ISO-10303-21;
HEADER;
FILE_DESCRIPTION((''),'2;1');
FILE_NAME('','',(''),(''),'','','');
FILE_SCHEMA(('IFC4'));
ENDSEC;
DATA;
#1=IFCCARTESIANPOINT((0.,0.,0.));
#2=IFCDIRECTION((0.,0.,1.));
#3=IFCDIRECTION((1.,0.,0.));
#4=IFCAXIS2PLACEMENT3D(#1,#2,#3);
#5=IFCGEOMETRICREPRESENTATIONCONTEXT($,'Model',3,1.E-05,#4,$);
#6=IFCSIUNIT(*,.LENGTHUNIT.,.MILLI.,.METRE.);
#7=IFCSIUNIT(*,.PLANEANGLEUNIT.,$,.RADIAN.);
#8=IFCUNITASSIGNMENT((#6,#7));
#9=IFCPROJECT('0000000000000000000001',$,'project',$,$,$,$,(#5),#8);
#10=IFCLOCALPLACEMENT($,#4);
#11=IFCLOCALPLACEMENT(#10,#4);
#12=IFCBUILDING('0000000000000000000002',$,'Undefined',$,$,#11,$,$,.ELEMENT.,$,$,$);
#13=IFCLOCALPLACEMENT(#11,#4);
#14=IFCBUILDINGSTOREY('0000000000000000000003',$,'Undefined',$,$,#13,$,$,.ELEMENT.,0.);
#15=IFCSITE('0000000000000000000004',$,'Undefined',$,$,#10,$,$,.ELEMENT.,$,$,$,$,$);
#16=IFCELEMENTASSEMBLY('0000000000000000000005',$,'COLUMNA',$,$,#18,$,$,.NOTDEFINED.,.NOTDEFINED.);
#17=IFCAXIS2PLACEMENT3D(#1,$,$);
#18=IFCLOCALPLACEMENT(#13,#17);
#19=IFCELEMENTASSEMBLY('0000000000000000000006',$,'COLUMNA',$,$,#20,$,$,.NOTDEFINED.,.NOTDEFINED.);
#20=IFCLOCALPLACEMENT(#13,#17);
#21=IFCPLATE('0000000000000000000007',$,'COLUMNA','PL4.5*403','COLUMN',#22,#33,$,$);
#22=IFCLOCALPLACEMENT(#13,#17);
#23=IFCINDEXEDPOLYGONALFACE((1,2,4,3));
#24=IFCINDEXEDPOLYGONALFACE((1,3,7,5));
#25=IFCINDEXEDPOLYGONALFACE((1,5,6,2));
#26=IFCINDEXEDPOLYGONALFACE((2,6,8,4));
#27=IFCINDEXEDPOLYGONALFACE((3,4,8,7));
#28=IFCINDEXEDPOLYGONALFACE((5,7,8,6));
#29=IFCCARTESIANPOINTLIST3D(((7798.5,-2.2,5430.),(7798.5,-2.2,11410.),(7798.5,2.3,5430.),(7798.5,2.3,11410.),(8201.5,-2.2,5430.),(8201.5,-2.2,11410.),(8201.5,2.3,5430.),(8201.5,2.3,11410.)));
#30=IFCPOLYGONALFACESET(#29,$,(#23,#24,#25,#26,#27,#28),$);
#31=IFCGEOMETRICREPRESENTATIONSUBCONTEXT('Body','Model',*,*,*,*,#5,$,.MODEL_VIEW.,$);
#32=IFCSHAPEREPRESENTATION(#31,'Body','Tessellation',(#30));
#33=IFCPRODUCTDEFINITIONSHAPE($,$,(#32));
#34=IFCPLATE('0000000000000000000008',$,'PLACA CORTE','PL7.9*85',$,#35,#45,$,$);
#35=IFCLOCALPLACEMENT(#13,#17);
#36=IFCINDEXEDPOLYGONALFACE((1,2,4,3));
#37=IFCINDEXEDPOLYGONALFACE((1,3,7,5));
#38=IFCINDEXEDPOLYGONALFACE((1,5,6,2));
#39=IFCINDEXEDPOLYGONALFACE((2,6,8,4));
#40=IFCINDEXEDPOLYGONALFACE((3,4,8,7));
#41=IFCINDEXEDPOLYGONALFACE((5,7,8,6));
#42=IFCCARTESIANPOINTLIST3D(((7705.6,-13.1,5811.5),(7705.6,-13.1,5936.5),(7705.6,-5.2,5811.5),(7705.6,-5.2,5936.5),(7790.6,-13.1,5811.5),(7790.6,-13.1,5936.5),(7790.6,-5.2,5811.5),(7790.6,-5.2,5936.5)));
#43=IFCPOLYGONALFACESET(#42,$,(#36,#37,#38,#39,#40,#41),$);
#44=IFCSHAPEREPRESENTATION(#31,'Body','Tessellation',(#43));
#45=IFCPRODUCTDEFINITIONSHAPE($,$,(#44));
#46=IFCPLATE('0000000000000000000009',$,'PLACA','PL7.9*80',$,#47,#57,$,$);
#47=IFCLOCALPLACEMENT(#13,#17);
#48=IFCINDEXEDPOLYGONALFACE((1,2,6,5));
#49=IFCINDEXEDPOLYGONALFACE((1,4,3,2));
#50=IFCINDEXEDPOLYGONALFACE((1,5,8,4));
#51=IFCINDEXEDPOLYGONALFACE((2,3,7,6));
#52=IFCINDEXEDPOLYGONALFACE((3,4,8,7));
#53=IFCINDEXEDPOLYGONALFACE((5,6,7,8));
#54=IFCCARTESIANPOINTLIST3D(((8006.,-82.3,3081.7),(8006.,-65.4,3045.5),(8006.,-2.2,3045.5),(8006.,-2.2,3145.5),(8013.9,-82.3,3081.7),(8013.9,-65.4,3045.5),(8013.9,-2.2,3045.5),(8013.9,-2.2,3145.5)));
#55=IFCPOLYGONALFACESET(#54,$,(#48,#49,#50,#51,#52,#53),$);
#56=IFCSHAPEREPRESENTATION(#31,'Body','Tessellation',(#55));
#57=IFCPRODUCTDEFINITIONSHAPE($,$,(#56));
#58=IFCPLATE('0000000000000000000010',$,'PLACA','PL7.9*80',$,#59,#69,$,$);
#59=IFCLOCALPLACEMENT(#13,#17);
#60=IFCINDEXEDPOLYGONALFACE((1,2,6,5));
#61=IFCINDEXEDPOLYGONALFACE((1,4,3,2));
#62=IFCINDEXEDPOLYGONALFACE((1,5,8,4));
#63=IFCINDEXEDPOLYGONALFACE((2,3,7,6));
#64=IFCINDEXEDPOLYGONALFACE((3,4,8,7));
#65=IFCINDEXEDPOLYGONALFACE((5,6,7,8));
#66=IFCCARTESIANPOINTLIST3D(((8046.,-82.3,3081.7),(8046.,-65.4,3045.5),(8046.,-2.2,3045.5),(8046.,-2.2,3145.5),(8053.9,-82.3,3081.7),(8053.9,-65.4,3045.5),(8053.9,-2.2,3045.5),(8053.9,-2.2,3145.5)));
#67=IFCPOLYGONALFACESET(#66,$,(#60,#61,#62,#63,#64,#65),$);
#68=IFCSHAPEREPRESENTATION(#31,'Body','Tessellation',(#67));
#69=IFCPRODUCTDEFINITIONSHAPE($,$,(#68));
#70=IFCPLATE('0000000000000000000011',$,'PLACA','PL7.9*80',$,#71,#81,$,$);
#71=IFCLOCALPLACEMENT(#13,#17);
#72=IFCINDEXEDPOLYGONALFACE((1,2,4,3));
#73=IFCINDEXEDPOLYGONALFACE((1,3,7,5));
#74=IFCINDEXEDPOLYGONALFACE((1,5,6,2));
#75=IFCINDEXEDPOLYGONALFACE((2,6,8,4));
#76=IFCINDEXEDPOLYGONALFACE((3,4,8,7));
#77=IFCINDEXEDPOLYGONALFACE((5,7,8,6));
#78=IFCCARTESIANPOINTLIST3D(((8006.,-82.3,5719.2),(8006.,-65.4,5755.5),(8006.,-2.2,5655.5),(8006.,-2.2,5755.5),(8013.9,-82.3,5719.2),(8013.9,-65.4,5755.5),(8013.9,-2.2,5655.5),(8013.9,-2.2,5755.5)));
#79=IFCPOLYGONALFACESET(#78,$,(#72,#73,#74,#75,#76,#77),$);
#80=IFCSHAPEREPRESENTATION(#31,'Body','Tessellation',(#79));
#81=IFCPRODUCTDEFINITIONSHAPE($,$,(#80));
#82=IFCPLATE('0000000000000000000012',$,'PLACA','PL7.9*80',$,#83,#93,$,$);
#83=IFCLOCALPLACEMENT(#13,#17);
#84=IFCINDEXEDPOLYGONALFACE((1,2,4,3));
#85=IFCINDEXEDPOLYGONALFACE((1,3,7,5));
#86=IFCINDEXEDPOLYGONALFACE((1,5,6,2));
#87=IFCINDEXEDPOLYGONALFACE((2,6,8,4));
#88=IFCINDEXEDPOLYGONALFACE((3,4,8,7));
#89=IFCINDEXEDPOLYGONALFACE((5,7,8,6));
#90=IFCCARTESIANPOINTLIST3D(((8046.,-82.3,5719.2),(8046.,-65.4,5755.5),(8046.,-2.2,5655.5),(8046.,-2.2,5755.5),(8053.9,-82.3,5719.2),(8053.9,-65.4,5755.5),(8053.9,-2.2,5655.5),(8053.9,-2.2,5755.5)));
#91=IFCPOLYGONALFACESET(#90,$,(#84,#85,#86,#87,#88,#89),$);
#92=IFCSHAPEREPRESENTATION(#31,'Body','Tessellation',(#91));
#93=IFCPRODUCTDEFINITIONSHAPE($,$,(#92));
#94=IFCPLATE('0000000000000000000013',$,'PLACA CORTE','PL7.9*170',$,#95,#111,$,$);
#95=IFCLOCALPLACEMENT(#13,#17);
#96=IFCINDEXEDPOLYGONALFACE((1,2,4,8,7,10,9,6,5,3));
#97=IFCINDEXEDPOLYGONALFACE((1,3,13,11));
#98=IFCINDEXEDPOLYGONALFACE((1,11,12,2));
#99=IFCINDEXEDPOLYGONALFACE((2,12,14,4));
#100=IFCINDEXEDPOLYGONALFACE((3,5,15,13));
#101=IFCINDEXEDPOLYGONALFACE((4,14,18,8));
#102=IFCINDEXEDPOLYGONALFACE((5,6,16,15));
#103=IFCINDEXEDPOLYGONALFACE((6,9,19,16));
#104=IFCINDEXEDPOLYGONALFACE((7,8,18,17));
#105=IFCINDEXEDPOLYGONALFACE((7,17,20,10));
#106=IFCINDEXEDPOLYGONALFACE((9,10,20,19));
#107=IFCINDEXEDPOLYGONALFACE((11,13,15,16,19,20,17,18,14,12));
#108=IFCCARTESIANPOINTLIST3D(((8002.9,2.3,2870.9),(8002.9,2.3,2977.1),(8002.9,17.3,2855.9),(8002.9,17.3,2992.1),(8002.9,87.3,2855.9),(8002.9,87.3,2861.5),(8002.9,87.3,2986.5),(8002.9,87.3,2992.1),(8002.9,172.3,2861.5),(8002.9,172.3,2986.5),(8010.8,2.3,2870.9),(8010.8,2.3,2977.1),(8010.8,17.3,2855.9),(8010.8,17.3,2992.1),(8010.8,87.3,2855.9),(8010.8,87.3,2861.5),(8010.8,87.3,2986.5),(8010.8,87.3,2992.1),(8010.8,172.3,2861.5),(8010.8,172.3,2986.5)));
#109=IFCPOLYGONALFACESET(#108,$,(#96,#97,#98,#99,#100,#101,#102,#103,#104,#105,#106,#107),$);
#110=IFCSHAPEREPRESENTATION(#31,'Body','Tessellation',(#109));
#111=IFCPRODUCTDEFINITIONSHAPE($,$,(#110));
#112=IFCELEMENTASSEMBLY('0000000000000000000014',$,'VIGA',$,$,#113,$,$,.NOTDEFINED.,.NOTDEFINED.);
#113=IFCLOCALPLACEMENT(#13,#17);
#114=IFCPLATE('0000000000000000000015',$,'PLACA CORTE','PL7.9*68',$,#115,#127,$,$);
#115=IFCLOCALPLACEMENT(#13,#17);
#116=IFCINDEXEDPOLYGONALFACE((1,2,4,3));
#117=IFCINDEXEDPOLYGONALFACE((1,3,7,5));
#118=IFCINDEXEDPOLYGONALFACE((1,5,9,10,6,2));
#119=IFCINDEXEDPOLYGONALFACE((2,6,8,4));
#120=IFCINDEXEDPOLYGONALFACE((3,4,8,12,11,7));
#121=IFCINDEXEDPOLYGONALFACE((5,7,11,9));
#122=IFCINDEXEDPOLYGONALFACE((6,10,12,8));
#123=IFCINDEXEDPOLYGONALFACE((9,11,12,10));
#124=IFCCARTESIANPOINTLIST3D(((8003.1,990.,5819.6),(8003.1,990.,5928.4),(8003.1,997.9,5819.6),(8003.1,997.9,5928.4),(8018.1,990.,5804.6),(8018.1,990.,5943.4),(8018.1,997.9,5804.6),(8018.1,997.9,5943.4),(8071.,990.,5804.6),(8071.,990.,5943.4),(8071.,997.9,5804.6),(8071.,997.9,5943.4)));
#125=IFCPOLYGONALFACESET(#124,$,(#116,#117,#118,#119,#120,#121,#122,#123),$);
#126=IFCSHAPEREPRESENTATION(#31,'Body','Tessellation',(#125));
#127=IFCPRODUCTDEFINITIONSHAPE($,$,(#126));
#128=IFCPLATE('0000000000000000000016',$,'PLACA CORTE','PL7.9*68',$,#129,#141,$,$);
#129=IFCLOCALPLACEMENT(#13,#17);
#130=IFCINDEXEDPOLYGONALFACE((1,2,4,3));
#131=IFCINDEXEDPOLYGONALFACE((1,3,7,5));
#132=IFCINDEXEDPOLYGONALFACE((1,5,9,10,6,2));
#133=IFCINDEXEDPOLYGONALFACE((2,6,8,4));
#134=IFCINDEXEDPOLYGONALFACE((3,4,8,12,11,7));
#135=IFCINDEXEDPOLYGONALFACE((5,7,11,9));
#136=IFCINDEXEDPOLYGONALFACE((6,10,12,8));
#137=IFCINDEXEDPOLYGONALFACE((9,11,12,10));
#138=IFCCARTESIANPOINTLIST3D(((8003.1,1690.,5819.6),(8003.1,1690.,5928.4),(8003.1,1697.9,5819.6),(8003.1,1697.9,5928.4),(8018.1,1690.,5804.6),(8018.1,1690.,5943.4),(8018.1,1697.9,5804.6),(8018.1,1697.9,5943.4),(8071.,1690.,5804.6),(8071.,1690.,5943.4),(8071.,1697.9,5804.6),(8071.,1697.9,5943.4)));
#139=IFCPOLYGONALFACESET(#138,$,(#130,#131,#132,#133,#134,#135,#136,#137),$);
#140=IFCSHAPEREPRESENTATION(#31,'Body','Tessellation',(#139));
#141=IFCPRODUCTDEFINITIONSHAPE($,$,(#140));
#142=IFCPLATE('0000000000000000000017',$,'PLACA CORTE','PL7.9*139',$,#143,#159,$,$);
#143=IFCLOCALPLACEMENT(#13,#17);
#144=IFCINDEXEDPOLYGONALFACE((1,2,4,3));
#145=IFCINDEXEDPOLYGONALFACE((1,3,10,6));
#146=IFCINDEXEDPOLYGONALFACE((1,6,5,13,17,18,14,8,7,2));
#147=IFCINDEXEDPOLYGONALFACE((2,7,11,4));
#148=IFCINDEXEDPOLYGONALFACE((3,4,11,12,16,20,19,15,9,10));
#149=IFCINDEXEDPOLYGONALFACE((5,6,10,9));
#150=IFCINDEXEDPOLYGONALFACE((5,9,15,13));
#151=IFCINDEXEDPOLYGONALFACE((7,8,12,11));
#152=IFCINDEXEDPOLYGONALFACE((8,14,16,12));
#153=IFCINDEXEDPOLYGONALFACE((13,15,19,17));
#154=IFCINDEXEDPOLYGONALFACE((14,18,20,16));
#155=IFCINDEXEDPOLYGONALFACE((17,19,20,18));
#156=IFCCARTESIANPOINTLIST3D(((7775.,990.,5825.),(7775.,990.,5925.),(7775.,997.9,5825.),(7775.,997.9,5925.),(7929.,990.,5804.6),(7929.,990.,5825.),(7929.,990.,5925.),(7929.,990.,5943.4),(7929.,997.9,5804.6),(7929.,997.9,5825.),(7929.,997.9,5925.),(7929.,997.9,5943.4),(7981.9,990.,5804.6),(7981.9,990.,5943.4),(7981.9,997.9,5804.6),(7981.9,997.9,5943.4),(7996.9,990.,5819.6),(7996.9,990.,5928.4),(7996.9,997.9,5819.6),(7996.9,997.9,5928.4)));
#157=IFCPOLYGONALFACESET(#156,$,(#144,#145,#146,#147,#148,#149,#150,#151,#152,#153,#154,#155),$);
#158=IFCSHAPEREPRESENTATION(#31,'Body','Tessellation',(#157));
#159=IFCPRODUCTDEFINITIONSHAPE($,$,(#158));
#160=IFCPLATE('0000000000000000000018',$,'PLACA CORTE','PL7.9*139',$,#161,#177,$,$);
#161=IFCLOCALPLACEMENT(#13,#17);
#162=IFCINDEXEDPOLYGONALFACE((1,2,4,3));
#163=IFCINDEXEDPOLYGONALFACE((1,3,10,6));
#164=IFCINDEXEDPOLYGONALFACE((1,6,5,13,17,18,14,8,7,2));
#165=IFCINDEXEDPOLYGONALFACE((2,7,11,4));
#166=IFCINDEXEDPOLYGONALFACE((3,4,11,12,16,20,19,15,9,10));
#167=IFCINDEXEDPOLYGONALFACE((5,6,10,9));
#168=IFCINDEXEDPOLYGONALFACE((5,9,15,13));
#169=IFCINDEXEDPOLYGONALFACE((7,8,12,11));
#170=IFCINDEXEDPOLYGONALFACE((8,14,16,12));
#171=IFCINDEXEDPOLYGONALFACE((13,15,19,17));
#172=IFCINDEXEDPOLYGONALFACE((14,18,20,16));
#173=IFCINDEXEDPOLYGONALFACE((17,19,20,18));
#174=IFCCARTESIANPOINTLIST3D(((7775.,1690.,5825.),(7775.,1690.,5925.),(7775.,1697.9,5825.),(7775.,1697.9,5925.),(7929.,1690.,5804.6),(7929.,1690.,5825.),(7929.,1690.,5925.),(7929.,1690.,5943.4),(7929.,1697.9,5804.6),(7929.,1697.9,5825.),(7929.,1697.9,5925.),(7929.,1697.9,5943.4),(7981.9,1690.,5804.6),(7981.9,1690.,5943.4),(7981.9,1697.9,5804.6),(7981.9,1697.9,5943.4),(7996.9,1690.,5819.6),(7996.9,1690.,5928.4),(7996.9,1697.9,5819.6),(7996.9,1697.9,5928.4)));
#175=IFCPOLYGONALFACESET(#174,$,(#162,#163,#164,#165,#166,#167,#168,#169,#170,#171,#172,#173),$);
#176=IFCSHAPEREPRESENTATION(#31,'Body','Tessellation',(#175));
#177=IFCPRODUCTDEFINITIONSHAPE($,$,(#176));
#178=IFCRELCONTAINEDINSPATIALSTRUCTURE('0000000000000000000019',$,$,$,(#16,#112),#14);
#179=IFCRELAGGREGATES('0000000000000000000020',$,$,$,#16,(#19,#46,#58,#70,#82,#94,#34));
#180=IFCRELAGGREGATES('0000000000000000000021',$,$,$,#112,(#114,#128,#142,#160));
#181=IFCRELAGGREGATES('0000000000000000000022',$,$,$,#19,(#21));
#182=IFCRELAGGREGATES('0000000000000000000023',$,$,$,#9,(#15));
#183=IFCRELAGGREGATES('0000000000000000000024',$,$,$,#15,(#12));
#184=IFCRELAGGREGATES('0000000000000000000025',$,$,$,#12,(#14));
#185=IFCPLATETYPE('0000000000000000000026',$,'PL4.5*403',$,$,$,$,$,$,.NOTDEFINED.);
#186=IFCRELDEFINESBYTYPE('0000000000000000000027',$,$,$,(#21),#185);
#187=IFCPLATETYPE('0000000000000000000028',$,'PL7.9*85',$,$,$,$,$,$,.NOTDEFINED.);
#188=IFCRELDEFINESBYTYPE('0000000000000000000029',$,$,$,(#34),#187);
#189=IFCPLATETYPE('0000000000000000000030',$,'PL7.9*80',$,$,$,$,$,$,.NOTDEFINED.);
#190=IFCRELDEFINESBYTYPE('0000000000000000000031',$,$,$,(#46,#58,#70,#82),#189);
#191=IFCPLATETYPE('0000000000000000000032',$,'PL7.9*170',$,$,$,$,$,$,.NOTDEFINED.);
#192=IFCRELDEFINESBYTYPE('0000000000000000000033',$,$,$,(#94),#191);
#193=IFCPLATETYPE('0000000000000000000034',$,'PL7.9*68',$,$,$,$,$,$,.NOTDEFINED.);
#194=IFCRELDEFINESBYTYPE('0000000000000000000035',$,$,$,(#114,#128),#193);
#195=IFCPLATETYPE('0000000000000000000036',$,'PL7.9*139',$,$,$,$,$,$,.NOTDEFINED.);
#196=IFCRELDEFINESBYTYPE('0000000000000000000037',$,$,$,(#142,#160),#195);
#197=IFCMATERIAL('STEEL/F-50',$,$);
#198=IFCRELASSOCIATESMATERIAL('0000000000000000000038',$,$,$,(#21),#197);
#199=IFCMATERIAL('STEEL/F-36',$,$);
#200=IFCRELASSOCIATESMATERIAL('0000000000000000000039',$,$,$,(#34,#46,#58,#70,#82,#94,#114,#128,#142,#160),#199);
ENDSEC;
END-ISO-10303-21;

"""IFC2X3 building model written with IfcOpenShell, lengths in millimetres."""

from ifc_helpers import new_model, si_unit, frame, origin_with_axes, place, context, subcontext, project, spatial, polyline, outline, extrude, material, type_object, element, aggregate, save


model = new_model("IFC2X3")

# Units and contexts
model_context = context("Model", 3, precision=1e-05, world=origin_with_axes())
body_context = subcontext(model_context, "Body", "Model", "MODEL_VIEW")
ifc_project = project(units=[si_unit("LENGTHUNIT", "METRE", prefix="MILLI"), si_unit("PLANEANGLEUNIT", "RADIAN")], contexts=[model_context])

# Site, building, storey
site_placement = place(None, origin_with_axes())
site = spatial("IfcSite", under=ifc_project, at=site_placement, Name="Undefined", CompositionType="ELEMENT")
building_placement = place(site_placement, origin_with_axes())
building = spatial("IfcBuilding", under=site, at=building_placement, Name="Undefined", CompositionType="ELEMENT")
storey_placement = place(building_placement, origin_with_axes())
storey = spatial("IfcBuildingStorey", under=building, at=storey_placement, Name="Undefined", CompositionType="ELEMENT", Elevation=0.0)

# Element assembly
assembly_1_placement = place(storey_placement, origin_with_axes())
assembly_1 = element("IfcElementAssembly", 1, at=assembly_1_placement, inside=storey, Name="COLUMNA", AssemblyPlace="NOTDEFINED", PredefinedType="NOTDEFINED")
ifc_material_1 = material(Name="STEEL/F-50")

# Shared definitions
ifc_material_2 = material(Name="STEEL/F-36")

# Element assembly, plate
assembly_2_placement = place(assembly_1_placement, origin_with_axes())
assembly_2 = element("IfcElementAssembly", 2, at=assembly_2_placement, Name="COLUMNA", AssemblyPlace="NOTDEFINED", PredefinedType="NOTDEFINED")
plate_type_1 = type_object("IfcPlateType", Name="PL4.5*403", PredefinedType="NOTDEFINED")
plate_1_placement = place(assembly_2_placement, frame((8000.0, 0.0, 5430.0), z_axis=(0.0, -1.0, 0.0), x_axis=(0.0, 0.0, 1.0)))
plate_1 = element("IfcPlate", 3, at=plate_1_placement, type_object=plate_type_1, material=ifc_material_1, Name="COLUMNA", Description="PL4.5*403", ObjectType="COLUMN", context=body_context, shape_type="SweptSolid", body=[
    extrude(outline(polyline([(0.0, -201.5), (0.0, 201.5), (5980.0, 201.5), (5980.0, -201.5), (0.0, -201.5)])), frame((0.0, 0.0, -2.2), z_axis=(0.0, 0.0, 1.0), x_axis=(1.0, 0.0, 0.0)), (0.0, 0.0, 1.0), 4.5),
])

# Plates
plate_type_2 = type_object("IfcPlateType", Name="PL7.9*85", PredefinedType="NOTDEFINED")
plate_2_placement = place(assembly_1_placement, frame((7790.6, -9.1, 5811.5), z_axis=(0.000002, 1.0, 0.0), x_axis=(-1.0, 0.000002, 0.0)))
plate_2 = element("IfcPlate", 4, at=plate_2_placement, type_object=plate_type_2, material=ifc_material_2, Name="PLACA CORTE", Description="PL7.9*85", context=body_context, shape_type="SweptSolid", body=[
    extrude(outline(polyline([(0.0, 0.0), (85.0, 0.0), (85.0, 125.0), (0.0, 125.0), (0.0, 0.0)])), frame((0.0, 0.0, -4.0), z_axis=(0.0, 0.0, 1.0), x_axis=(1.0, 0.0, 0.0)), (0.0, 0.0, 1.0), 7.9),
])
plate_type_3 = type_object("IfcPlateType", Name="PL7.9*80", PredefinedType="NOTDEFINED")
plate_3_placement = place(assembly_1_placement, frame((8010.0, -2.2, 3045.5), z_axis=(-1.0, -0.000002, -0.000004), x_axis=(0.000002, -1.0, -0.000001)))
plate_3 = element("IfcPlate", 5, at=plate_3_placement, type_object=plate_type_3, material=ifc_material_2, Name="PLACA", Description="PL7.9*80", context=body_context, shape_type="SweptSolid", body=[
    extrude(outline(polyline([(0.0, 0.0), (63.2, 0.0), (80.1, 36.3), (0.0, 100.0), (0.0, 0.0)])), frame((0.0, 0.0, -4.0), z_axis=(0.0, 0.0, 1.0), x_axis=(1.0, 0.0, 0.0)), (0.0, 0.0, 1.0), 7.9),
])
plate_4_placement = place(assembly_1_placement, frame((8050.0, -2.2, 3045.5), z_axis=(-1.0, 0.000001, 0.0), x_axis=(-0.000001, -1.0, -0.000001)))
plate_4 = element("IfcPlate", 6, at=plate_4_placement, type_object=plate_type_3, material=ifc_material_2, Name="PLACA", Description="PL7.9*80", context=body_context, shape_type="SweptSolid", body=[
    extrude(outline(polyline([(0.0, 0.0), (63.2, 0.0), (80.1, 36.3), (0.0, 100.0), (0.0, 0.0)])), frame((0.0, 0.0, -4.0), z_axis=(0.0, 0.0, 1.0), x_axis=(1.0, 0.0, 0.0)), (0.0, 0.0, 1.0), 7.9),
])
plate_5_placement = place(assembly_1_placement, frame((8010.0, -2.2, 5755.5), z_axis=(1.0, 0.000001, -0.000004), x_axis=(0.000002, -1.0, 0.000001)))
plate_5 = element("IfcPlate", 7, at=plate_5_placement, type_object=plate_type_3, material=ifc_material_2, Name="PLACA", Description="PL7.9*80", context=body_context, shape_type="SweptSolid", body=[
    extrude(outline(polyline([(0.0, 0.0), (63.2, 0.0), (80.1, 36.3), (0.0, 100.0), (0.0, 0.0)])), frame((0.0, 0.0, -4.0), z_axis=(0.0, 0.0, 1.0), x_axis=(1.0, 0.0, 0.0)), (0.0, 0.0, 1.0), 7.9),
])
plate_6_placement = place(assembly_1_placement, frame((8050.0, -2.2, 5755.5), z_axis=(1.0, -0.000001, 0.0), x_axis=(-0.000001, -1.0, 0.000001)))
plate_6 = element("IfcPlate", 8, at=plate_6_placement, type_object=plate_type_3, material=ifc_material_2, Name="PLACA", Description="PL7.9*80", context=body_context, shape_type="SweptSolid", body=[
    extrude(outline(polyline([(0.0, 0.0), (63.2, 0.0), (80.1, 36.3), (0.0, 100.0), (0.0, 0.0)])), frame((0.0, 0.0, -4.0), z_axis=(0.0, 0.0, 1.0), x_axis=(1.0, 0.0, 0.0)), (0.0, 0.0, 1.0), 7.9),
])
plate_type_4 = type_object("IfcPlateType", Name="PL7.9*170", PredefinedType="NOTDEFINED")
plate_7_placement = place(assembly_1_placement, frame((8006.8, 2.3, 2992.1), z_axis=(1.0, 0.0, 0.0), x_axis=(0.0, 0.0, -1.0)))
plate_7 = element("IfcPlate", 9, at=plate_7_placement, type_object=plate_type_4, material=ifc_material_2, Name="PLACA CORTE", Description="PL7.9*170", context=body_context, shape_type="SweptSolid", body=[
    extrude(outline(polyline([(0.0, 15.0), (15.0, 0.0), (121.2, 0.0), (136.2, 15.0), (136.2, 85.0), (130.6, 85.0), (130.6, 170.0), (5.6, 170.0), (5.6, 85.0), (0.0, 85.0), (0.0, 15.0)])), frame((0.0, 0.0, -4.0), z_axis=(0.0, 0.0, 1.0), x_axis=(1.0, 0.0, 0.0)), (0.0, 0.0, 1.0), 7.9),
])
aggregate(assembly_1, [assembly_2, plate_3, plate_4, plate_5, plate_6, plate_7, plate_2])

# Element assembly, plates
assembly_3_placement = place(storey_placement, origin_with_axes())
assembly_3 = element("IfcElementAssembly", 10, at=assembly_3_placement, inside=storey, Name="VIGA", AssemblyPlace="NOTDEFINED", PredefinedType="NOTDEFINED")
plate_type_5 = type_object("IfcPlateType", Name="PL7.9*68", PredefinedType="NOTDEFINED")
plate_8_placement = place(assembly_3_placement, frame((8003.1, 993.9, 5804.6), z_axis=(0.000001, -1.0, 0.0), x_axis=(1.0, 0.000001, 0.0)))
plate_8 = element("IfcPlate", 11, at=plate_8_placement, type_object=plate_type_5, material=ifc_material_2, Name="PLACA CORTE", Description="PL7.9*68", context=body_context, shape_type="SweptSolid", body=[
    extrude(outline(polyline([(0.0, 15.0), (15.0, 0.0), (67.9, 0.0), (67.9, 138.8), (15.0, 138.8), (0.0, 123.8), (0.0, 15.0)])), frame((0.0, 0.0, -4.0), z_axis=(0.0, 0.0, 1.0), x_axis=(1.0, 0.0, 0.0)), (0.0, 0.0, 1.0), 7.9),
])
plate_9_placement = place(assembly_3_placement, frame((8003.1, 1693.9, 5804.6), z_axis=(0.000001, -1.0, 0.0), x_axis=(1.0, 0.000001, 0.0)))
plate_9 = element("IfcPlate", 12, at=plate_9_placement, type_object=plate_type_5, material=ifc_material_2, Name="PLACA CORTE", Description="PL7.9*68", context=body_context, shape_type="SweptSolid", body=[
    extrude(outline(polyline([(0.0, 15.0), (15.0, 0.0), (67.9, 0.0), (67.9, 138.8), (15.0, 138.8), (0.0, 123.8), (0.0, 15.0)])), frame((0.0, 0.0, -4.0), z_axis=(0.0, 0.0, 1.0), x_axis=(1.0, 0.0, 0.0)), (0.0, 0.0, 1.0), 7.9),
])
plate_type_6 = type_object("IfcPlateType", Name="PL7.9*139", PredefinedType="NOTDEFINED")
plate_10_placement = place(assembly_3_placement, frame((7996.9, 993.9, 5804.6), z_axis=(0.000001, 1.0, 0.0), x_axis=(-1.0, 0.000001, 0.0)))
plate_10 = element("IfcPlate", 13, at=plate_10_placement, type_object=plate_type_6, material=ifc_material_2, Name="PLACA CORTE", Description="PL7.9*139", context=body_context, shape_type="SweptSolid", body=[
    extrude(outline(polyline([(0.0, 15.0), (15.0, 0.0), (67.9, 0.0), (67.9, 20.4), (221.9, 20.4), (221.9, 120.4), (67.9, 120.4), (67.9, 138.8), (15.0, 138.8), (0.0, 123.8), (0.0, 15.0)])), frame((0.0, 0.0, -4.0), z_axis=(0.0, 0.0, 1.0), x_axis=(1.0, 0.0, 0.0)), (0.0, 0.0, 1.0), 7.9),
])
plate_11_placement = place(assembly_3_placement, frame((7996.9, 1693.9, 5804.6), z_axis=(0.000001, 1.0, 0.0), x_axis=(-1.0, 0.000001, 0.0)))
plate_11 = element("IfcPlate", 14, at=plate_11_placement, type_object=plate_type_6, material=ifc_material_2, Name="PLACA CORTE", Description="PL7.9*139", context=body_context, shape_type="SweptSolid", body=[
    extrude(outline(polyline([(0.0, 15.0), (15.0, 0.0), (67.9, 0.0), (67.9, 20.4), (221.9, 20.4), (221.9, 120.4), (67.9, 120.4), (67.9, 138.8), (15.0, 138.8), (0.0, 123.8), (0.0, 15.0)])), frame((0.0, 0.0, -4.0), z_axis=(0.0, 0.0, 1.0), x_axis=(1.0, 0.0, 0.0)), (0.0, 0.0, 1.0), 7.9),
])
aggregate(assembly_3, [plate_8, plate_9, plate_10, plate_11])

aggregate(assembly_2, [plate_1])

save(model, "model.ifc")
